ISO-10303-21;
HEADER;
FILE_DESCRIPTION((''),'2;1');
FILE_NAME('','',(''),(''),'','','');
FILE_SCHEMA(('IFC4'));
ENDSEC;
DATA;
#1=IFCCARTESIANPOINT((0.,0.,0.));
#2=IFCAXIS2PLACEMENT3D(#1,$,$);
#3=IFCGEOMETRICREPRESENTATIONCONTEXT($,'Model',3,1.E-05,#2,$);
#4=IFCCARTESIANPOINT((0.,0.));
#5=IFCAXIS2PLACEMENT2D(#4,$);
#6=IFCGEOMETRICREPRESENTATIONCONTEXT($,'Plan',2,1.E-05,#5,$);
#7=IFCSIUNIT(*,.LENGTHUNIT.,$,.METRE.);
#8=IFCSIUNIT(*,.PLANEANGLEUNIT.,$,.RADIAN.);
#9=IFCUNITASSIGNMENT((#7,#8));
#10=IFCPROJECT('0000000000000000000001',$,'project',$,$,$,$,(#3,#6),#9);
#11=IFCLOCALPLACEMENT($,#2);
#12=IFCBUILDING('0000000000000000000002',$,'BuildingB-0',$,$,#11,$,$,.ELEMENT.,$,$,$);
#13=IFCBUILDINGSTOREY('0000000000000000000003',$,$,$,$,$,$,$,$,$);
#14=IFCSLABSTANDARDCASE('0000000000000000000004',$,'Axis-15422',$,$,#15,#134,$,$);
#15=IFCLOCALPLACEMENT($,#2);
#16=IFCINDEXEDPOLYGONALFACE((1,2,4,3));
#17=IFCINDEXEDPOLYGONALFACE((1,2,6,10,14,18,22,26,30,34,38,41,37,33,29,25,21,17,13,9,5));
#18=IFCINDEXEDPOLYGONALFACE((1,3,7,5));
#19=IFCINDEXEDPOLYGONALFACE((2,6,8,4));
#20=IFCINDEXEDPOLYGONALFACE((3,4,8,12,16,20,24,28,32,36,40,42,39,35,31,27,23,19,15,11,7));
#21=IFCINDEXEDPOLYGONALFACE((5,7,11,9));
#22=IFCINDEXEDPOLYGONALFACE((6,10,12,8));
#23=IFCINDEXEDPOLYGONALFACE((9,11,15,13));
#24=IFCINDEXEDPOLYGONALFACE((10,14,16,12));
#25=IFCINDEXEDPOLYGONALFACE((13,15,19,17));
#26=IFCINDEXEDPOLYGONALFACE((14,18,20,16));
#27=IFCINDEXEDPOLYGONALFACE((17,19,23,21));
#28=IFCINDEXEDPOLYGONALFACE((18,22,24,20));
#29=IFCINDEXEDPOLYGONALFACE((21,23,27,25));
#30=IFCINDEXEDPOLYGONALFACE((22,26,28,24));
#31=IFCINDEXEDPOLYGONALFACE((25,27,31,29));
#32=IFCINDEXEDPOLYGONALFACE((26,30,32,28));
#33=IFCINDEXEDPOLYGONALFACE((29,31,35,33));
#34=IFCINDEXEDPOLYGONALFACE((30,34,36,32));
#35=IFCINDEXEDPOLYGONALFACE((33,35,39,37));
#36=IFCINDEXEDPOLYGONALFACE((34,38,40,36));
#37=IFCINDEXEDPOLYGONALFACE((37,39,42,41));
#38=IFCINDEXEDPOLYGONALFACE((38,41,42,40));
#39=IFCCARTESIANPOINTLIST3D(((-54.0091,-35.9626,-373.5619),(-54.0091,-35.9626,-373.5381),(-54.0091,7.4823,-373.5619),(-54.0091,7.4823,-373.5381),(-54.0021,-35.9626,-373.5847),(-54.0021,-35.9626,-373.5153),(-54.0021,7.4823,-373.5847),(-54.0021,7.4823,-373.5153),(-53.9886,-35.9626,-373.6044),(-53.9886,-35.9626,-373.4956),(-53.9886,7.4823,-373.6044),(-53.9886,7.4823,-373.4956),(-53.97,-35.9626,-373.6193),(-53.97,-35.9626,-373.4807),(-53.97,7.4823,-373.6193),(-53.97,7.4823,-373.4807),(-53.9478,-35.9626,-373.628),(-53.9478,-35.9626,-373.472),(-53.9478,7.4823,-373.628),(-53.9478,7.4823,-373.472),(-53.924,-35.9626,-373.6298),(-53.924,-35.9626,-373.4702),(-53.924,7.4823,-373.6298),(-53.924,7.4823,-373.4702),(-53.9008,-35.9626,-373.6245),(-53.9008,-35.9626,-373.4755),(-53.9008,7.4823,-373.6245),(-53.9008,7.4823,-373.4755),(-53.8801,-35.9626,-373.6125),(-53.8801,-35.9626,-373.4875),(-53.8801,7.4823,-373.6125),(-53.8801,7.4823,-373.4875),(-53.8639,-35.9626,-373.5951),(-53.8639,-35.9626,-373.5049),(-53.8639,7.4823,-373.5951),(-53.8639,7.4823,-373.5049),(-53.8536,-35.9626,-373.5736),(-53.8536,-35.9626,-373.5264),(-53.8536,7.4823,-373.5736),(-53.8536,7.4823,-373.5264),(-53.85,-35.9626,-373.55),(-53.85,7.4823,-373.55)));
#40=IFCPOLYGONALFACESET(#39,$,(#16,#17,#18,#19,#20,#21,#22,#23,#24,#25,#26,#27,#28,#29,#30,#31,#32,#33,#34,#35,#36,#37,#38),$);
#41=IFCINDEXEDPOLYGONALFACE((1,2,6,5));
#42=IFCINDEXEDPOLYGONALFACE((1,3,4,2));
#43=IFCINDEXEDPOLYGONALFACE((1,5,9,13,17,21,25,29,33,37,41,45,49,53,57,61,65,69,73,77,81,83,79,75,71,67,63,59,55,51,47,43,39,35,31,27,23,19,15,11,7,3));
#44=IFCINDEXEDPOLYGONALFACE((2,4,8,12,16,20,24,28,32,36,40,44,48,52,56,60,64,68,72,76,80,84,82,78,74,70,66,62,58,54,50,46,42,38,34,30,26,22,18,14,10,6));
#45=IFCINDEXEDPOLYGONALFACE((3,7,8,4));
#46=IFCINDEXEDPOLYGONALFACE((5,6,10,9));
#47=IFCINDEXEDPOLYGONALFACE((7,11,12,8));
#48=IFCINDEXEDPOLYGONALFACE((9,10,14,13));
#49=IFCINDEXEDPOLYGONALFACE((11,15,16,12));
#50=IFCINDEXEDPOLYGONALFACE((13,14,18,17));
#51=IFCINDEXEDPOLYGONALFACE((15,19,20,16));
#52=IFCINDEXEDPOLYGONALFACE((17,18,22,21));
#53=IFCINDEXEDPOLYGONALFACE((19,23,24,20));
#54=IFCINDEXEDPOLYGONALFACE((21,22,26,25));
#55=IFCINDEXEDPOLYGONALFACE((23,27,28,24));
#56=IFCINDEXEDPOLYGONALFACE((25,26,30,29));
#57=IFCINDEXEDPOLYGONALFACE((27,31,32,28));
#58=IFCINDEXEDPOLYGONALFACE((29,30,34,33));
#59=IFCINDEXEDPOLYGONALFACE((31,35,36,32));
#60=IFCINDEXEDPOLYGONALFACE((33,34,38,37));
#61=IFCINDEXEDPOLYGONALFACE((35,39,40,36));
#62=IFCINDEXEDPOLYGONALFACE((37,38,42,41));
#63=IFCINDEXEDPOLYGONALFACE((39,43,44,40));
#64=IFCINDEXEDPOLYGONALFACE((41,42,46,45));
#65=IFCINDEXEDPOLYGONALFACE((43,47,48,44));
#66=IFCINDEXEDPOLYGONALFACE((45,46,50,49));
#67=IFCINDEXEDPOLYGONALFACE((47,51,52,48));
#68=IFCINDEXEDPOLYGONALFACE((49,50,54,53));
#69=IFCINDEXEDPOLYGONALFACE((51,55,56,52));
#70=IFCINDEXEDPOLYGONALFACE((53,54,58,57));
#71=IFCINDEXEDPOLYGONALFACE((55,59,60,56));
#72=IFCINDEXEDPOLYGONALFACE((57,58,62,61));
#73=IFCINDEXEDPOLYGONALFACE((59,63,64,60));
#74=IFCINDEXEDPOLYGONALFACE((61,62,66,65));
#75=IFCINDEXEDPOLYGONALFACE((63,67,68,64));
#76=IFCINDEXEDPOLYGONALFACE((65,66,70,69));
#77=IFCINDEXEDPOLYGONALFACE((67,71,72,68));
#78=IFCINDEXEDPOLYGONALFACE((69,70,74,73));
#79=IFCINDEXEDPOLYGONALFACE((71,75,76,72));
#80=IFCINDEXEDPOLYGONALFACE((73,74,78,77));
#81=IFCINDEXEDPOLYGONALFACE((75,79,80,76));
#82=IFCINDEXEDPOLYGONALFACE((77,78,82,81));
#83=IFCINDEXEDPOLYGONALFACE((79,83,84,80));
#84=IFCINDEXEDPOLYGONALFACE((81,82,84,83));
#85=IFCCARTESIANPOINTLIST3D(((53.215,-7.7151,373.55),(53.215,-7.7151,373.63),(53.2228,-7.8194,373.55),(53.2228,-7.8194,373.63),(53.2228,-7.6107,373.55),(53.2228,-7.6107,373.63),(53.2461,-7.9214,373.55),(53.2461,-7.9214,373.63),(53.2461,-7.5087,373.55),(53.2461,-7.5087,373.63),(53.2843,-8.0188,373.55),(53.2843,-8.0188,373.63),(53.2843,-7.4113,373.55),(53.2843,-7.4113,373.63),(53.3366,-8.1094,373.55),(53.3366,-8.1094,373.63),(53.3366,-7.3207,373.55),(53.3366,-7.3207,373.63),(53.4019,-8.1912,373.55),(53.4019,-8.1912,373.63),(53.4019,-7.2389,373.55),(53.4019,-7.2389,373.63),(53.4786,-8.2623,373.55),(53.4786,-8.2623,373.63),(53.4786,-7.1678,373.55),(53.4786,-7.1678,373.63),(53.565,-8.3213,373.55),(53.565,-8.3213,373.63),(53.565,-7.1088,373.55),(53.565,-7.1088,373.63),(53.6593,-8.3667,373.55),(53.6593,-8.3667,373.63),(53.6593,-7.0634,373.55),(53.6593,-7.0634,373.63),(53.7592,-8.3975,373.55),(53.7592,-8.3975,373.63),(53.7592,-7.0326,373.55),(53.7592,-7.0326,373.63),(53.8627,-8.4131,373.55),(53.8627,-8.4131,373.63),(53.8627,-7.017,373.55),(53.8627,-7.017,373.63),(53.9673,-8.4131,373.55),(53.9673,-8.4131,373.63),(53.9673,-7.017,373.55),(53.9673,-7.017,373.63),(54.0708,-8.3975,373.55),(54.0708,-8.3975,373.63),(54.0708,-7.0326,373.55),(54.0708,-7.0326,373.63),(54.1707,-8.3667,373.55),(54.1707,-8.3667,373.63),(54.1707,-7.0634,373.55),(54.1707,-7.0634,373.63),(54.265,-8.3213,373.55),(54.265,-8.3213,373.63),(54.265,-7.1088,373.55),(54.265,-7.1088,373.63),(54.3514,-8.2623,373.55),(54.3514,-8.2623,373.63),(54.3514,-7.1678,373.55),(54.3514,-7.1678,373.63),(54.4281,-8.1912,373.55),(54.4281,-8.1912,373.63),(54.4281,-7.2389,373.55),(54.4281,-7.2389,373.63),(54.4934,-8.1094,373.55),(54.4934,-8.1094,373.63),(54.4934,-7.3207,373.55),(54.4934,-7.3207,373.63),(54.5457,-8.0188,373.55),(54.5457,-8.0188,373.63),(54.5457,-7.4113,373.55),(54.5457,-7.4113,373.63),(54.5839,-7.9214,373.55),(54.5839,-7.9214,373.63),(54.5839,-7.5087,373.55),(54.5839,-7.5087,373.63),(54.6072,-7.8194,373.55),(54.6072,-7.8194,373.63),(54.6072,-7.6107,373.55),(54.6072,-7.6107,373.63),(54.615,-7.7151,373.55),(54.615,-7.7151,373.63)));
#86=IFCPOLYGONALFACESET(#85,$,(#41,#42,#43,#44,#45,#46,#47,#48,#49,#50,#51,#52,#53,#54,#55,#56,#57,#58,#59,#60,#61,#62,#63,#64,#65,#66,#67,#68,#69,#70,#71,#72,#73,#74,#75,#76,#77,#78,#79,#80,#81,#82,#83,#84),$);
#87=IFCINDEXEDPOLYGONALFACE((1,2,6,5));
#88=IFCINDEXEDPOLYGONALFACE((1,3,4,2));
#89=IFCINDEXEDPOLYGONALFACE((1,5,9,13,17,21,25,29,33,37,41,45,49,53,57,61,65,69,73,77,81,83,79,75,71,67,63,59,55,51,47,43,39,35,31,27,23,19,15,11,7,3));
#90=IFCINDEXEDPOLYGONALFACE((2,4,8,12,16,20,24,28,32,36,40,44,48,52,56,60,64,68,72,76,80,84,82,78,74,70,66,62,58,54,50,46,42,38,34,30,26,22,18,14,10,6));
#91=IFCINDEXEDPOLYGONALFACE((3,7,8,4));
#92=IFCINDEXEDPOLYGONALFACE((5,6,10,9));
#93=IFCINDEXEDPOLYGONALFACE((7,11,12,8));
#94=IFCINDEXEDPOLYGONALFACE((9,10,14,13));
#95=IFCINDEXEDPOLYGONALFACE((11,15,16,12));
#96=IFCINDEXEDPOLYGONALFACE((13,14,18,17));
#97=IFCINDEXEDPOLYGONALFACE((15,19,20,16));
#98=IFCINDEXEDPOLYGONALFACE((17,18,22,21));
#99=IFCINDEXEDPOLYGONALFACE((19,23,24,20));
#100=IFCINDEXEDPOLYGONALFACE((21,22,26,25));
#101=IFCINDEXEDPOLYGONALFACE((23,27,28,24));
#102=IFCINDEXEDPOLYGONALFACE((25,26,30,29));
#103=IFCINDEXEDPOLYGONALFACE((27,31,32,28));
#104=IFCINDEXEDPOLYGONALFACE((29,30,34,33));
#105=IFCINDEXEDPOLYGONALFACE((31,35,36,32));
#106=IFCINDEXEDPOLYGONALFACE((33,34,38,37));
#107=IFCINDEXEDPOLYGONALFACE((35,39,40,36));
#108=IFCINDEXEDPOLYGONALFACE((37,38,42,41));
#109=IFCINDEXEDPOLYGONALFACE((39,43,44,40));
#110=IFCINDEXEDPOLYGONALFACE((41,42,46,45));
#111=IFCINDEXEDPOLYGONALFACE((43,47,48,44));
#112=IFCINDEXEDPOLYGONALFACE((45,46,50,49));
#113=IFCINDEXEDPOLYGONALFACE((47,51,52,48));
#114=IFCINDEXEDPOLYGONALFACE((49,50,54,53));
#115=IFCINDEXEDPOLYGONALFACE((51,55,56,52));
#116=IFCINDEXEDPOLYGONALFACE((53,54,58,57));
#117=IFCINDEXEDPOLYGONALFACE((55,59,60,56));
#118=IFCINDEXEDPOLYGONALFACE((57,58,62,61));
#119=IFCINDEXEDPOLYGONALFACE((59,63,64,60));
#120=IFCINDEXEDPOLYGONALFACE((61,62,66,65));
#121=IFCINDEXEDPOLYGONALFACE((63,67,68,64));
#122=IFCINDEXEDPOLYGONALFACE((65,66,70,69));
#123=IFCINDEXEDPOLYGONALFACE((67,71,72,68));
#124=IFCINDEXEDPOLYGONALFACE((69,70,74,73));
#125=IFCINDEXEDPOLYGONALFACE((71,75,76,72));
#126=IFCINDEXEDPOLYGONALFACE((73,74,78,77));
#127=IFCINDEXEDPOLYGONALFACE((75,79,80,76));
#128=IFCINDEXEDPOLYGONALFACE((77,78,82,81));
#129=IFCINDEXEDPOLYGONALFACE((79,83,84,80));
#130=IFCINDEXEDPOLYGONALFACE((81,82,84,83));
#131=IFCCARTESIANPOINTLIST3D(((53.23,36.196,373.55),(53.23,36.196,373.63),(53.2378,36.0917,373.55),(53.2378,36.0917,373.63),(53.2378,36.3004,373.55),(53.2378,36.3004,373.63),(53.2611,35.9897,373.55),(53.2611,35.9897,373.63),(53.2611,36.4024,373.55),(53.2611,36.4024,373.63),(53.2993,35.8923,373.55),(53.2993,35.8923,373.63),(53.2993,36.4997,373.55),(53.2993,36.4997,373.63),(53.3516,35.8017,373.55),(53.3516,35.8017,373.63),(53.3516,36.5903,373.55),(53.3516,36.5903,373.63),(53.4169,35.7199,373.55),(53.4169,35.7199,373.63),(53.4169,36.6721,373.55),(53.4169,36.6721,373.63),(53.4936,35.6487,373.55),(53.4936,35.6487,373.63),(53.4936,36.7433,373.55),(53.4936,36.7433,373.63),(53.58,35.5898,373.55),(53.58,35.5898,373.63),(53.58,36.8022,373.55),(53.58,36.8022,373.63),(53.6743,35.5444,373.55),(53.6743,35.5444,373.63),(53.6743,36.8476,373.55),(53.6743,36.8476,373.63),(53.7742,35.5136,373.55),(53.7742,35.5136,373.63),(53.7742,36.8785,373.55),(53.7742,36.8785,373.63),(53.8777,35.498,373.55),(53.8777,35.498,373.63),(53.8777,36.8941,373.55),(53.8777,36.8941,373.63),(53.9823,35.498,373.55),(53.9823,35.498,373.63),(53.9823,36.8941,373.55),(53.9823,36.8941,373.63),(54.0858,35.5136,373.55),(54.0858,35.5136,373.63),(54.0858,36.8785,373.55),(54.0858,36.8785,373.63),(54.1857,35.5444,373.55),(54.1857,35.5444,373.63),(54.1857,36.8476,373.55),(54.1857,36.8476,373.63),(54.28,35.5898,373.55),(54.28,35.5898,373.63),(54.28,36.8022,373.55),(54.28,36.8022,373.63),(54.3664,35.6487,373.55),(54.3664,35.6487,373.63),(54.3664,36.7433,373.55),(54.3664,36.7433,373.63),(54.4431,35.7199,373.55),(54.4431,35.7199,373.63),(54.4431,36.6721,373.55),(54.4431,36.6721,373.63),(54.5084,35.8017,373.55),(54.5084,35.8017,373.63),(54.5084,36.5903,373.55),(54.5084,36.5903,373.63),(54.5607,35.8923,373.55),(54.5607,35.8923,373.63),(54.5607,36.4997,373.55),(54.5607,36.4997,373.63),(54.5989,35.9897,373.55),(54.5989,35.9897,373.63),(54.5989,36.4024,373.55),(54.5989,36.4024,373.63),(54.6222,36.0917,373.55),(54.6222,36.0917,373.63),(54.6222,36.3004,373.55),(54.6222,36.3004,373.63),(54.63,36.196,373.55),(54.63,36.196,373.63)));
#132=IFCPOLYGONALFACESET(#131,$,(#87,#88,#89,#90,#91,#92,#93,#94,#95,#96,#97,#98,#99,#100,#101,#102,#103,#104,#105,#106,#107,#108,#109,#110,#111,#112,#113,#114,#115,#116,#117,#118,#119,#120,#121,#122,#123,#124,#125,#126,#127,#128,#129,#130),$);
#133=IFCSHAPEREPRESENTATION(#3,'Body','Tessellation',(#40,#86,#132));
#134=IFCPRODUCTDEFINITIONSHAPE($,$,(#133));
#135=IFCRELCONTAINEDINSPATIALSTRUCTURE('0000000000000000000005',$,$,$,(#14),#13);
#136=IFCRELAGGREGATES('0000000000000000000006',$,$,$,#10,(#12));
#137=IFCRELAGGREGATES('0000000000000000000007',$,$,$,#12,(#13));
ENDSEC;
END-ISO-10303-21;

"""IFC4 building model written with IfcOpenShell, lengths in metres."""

from ifc_helpers import new_model, entity, si_unit, frame, origin, origin_2d, place, context, project, spatial, circle, extrude, element, save


model = new_model("IFC4")

# Units and contexts
model_context = context("Model", 3, precision=1e-05, world=origin())
plan_context = context("Plan", 2, precision=1e-05, world=origin_2d())
ifc_project = project(units=[si_unit("LENGTHUNIT", "METRE"), si_unit("PLANEANGLEUNIT", "RADIAN")], contexts=[model_context, plan_context])

# Building, storey
building_placement = place(None, origin())
building = spatial("IfcBuilding", under=ifc_project, at=building_placement, Name="BuildingB-0", CompositionType="ELEMENT")
storey = spatial("IfcBuildingStorey", under=building)

# Slab
element("IfcSlabStandardCase", 1, inside=storey, Name="Axis-15422", context=model_context, shape_type="AdvancedSweptSolid", body=[
    entity("IfcSurfaceCurveSweptAreaSolid", entity("IfcCircleProfileDef", "AREA", None, None, 0.08), None, entity("IfcPolyline", [entity("IfcCartesianPoint", [53.93, -7.4823, 373.55]), entity("IfcCartesianPoint", [53.93, 35.9626, 373.55])]), None, None, entity("IfcPlane", entity("IfcAxis2Placement3D", entity("IfcCartesianPoint", [53.93, -7.4823, 373.55]), entity("IfcDirection", [0.0, 0.0, 1.0]), entity("IfcDirection", [1.0, 0.0, 0.0])))),
    extrude(circle(Radius=0.7), frame((53.915, -7.7151, 373.55)), (0.0, 0.0, 1.0), 0.08),
    extrude(circle(Radius=0.7), frame((53.93, 36.196, 373.55)), (0.0, 0.0, 1.0), 0.08),
])

save(model, "model.ifc")
